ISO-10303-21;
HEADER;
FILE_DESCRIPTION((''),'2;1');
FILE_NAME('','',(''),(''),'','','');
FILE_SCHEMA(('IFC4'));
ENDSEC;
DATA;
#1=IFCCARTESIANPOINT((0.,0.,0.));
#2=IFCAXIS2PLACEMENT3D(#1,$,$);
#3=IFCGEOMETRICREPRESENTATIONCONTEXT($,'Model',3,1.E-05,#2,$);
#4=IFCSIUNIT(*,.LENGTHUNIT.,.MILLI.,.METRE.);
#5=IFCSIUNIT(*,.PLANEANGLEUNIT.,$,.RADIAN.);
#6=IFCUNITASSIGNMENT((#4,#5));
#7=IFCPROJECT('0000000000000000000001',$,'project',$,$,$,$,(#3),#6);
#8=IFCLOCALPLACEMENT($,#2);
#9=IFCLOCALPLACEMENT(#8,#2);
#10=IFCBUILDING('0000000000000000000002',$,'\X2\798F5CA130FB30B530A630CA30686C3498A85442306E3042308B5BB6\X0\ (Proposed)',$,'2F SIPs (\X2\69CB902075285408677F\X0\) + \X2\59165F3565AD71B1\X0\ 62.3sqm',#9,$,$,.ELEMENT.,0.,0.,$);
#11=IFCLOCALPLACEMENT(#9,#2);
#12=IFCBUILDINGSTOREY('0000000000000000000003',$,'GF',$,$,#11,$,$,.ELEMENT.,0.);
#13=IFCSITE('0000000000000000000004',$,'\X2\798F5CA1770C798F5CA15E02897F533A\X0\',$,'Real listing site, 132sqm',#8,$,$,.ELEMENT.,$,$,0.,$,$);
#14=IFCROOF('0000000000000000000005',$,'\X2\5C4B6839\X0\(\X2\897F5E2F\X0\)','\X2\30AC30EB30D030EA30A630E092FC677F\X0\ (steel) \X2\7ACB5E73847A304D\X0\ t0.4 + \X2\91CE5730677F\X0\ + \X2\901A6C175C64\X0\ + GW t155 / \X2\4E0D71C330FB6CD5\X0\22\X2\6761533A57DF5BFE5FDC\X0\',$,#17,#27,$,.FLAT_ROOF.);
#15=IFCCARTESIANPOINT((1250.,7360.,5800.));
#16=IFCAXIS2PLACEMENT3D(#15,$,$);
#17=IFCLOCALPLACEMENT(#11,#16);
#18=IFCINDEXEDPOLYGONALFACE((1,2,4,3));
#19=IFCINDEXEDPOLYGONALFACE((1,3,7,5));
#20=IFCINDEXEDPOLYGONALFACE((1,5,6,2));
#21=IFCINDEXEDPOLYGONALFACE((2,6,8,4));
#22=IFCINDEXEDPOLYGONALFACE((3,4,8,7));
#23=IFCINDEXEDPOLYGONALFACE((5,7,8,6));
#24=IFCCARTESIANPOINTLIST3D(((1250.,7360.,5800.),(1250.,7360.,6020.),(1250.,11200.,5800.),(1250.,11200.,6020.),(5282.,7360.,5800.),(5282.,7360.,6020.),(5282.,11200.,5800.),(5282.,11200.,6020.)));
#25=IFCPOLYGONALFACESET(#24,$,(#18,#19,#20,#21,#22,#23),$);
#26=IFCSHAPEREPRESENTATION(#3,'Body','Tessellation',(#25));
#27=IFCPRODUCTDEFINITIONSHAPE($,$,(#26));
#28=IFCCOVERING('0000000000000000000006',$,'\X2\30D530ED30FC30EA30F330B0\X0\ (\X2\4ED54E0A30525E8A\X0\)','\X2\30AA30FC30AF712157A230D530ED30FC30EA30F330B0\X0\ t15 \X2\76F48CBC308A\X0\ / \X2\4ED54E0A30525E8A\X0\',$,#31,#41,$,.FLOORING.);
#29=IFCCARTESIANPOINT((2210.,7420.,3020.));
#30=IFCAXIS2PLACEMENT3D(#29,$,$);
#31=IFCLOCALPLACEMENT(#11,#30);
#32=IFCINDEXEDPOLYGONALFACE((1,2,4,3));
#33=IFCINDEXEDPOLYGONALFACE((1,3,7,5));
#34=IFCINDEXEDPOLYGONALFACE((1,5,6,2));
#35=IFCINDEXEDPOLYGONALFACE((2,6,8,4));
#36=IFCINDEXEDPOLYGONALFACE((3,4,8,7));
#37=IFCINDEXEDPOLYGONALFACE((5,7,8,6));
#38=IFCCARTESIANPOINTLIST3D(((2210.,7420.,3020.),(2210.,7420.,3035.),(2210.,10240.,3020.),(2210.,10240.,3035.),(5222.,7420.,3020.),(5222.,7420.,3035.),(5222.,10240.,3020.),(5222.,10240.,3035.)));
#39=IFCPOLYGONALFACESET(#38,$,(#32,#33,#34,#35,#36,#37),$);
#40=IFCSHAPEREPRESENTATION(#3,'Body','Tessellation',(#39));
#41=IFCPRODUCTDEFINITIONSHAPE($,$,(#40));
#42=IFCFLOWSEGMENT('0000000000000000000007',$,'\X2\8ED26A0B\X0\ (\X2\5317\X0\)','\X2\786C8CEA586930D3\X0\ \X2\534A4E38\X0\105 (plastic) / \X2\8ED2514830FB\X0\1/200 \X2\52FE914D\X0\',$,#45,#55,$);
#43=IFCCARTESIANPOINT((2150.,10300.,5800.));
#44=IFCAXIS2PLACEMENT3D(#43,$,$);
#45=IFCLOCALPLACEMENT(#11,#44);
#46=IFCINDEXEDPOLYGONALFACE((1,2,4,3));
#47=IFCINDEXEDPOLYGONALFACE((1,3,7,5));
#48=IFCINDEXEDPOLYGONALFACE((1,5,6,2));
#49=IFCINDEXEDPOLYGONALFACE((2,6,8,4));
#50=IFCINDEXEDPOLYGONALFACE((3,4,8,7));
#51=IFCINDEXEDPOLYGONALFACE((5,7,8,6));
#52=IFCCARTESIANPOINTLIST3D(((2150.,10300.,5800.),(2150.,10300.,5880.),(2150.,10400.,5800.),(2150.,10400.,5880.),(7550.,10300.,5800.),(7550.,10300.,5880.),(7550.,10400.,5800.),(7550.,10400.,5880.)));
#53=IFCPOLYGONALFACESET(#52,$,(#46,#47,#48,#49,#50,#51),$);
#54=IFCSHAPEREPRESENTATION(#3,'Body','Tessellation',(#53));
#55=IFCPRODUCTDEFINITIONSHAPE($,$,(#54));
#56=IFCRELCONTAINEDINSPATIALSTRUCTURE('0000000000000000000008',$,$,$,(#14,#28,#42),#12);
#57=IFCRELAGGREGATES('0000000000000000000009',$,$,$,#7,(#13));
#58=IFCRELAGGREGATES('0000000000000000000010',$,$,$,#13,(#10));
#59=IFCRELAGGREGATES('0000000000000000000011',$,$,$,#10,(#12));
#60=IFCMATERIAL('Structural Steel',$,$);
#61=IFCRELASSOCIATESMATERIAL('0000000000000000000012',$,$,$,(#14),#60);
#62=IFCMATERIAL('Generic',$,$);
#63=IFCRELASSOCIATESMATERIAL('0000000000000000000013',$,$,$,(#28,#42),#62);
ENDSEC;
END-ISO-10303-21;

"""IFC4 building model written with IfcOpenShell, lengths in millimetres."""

from ifc_helpers import new_model, si_unit, frame, frame_2d, origin, place, context, project, spatial, rectangle, extrude, material, element, save


model = new_model("IFC4")

# Units and contexts
model_context = context("Model", 3, precision=1e-05, world=origin())
ifc_project = project(units=[si_unit("LENGTHUNIT", "METRE", prefix="MILLI"), si_unit("PLANEANGLEUNIT", "RADIAN")], contexts=[model_context])

# Site, building, storey
site_placement = place(None, origin())
site = spatial("IfcSite", under=ifc_project, at=site_placement, Name="福岡県福岡市西区", ObjectType="Real listing site, 132sqm", CompositionType="ELEMENT", RefElevation=0.0)
building_placement = place(site_placement, origin())
building = spatial("IfcBuilding", under=site, at=building_placement, Name="福岡・サウナと水風呂のある家 (Proposed)", ObjectType="2F SIPs (構造用合板) + 外張断熱 62.3sqm", CompositionType="ELEMENT", ElevationOfRefHeight=0.0, ElevationOfTerrain=0.0)
storey_placement = place(building_placement, origin())
storey = spatial("IfcBuildingStorey", under=building, at=storey_placement, Name="GF", CompositionType="ELEMENT", Elevation=0.0)

# Roof
ifc_material_1 = material(Name="Structural Steel")
for number, where, name in (
    (1, (1250.0, 7360.0, 5800.0), "屋根(西帯)"),
):
    element("IfcRoof", number, at=place(storey_placement, frame(where)), inside=storey, material=ifc_material_1, Name=name, Description="ガルバリウム鋼板 (steel) 立平葺き t0.4 + 野地板 + 通気層 + GW t155 / 不燃・法22条区域対応", PredefinedType="FLAT_ROOF", context=model_context, shape_type="SweptSolid", body=[
        extrude(rectangle(XDim=4032.0, YDim=3840.0, at=frame_2d((2016.0, 1920.0))), frame((1250.0, 7360.0, 5800.0)), (0.0, 0.0, 1.0), 220.0),
    ])

# Covering
ifc_material_2 = material(Name="Generic")
covering_placement = place(storey_placement, frame((2210.0, 7420.0, 3020.0)))
element("IfcCovering", 2, at=covering_placement, inside=storey, material=ifc_material_2, Name="フローリング (仕上げ床)", Description="オーク無垢フローリング t15 直貼り / 仕上げ床", PredefinedType="FLOORING", context=model_context, shape_type="SweptSolid", body=[
    extrude(rectangle(XDim=3012.0, YDim=2820.0, at=frame_2d((1506.0, 1410.0))), frame((2210.0, 7420.0, 3020.0)), (0.0, 0.0, 1.0), 15.0),
])

# Flow segment
flow_segment_placement = place(storey_placement, frame((2150.0, 10300.0, 5800.0)))
element("IfcFlowSegment", 3, at=flow_segment_placement, inside=storey, material=ifc_material_2, Name="軒樋 (北)", Description="硬質塩ビ 半丸105 (plastic) / 軒先・1/200 勾配", context=model_context, shape_type="SweptSolid", body=[
    extrude(rectangle(XDim=5400.0, YDim=100.0, at=frame_2d((2700.0, 50.0))), frame((2150.0, 10300.0, 5800.0)), (0.0, 0.0, 1.0), 80.0),
])

save(model, "model.ifc")
